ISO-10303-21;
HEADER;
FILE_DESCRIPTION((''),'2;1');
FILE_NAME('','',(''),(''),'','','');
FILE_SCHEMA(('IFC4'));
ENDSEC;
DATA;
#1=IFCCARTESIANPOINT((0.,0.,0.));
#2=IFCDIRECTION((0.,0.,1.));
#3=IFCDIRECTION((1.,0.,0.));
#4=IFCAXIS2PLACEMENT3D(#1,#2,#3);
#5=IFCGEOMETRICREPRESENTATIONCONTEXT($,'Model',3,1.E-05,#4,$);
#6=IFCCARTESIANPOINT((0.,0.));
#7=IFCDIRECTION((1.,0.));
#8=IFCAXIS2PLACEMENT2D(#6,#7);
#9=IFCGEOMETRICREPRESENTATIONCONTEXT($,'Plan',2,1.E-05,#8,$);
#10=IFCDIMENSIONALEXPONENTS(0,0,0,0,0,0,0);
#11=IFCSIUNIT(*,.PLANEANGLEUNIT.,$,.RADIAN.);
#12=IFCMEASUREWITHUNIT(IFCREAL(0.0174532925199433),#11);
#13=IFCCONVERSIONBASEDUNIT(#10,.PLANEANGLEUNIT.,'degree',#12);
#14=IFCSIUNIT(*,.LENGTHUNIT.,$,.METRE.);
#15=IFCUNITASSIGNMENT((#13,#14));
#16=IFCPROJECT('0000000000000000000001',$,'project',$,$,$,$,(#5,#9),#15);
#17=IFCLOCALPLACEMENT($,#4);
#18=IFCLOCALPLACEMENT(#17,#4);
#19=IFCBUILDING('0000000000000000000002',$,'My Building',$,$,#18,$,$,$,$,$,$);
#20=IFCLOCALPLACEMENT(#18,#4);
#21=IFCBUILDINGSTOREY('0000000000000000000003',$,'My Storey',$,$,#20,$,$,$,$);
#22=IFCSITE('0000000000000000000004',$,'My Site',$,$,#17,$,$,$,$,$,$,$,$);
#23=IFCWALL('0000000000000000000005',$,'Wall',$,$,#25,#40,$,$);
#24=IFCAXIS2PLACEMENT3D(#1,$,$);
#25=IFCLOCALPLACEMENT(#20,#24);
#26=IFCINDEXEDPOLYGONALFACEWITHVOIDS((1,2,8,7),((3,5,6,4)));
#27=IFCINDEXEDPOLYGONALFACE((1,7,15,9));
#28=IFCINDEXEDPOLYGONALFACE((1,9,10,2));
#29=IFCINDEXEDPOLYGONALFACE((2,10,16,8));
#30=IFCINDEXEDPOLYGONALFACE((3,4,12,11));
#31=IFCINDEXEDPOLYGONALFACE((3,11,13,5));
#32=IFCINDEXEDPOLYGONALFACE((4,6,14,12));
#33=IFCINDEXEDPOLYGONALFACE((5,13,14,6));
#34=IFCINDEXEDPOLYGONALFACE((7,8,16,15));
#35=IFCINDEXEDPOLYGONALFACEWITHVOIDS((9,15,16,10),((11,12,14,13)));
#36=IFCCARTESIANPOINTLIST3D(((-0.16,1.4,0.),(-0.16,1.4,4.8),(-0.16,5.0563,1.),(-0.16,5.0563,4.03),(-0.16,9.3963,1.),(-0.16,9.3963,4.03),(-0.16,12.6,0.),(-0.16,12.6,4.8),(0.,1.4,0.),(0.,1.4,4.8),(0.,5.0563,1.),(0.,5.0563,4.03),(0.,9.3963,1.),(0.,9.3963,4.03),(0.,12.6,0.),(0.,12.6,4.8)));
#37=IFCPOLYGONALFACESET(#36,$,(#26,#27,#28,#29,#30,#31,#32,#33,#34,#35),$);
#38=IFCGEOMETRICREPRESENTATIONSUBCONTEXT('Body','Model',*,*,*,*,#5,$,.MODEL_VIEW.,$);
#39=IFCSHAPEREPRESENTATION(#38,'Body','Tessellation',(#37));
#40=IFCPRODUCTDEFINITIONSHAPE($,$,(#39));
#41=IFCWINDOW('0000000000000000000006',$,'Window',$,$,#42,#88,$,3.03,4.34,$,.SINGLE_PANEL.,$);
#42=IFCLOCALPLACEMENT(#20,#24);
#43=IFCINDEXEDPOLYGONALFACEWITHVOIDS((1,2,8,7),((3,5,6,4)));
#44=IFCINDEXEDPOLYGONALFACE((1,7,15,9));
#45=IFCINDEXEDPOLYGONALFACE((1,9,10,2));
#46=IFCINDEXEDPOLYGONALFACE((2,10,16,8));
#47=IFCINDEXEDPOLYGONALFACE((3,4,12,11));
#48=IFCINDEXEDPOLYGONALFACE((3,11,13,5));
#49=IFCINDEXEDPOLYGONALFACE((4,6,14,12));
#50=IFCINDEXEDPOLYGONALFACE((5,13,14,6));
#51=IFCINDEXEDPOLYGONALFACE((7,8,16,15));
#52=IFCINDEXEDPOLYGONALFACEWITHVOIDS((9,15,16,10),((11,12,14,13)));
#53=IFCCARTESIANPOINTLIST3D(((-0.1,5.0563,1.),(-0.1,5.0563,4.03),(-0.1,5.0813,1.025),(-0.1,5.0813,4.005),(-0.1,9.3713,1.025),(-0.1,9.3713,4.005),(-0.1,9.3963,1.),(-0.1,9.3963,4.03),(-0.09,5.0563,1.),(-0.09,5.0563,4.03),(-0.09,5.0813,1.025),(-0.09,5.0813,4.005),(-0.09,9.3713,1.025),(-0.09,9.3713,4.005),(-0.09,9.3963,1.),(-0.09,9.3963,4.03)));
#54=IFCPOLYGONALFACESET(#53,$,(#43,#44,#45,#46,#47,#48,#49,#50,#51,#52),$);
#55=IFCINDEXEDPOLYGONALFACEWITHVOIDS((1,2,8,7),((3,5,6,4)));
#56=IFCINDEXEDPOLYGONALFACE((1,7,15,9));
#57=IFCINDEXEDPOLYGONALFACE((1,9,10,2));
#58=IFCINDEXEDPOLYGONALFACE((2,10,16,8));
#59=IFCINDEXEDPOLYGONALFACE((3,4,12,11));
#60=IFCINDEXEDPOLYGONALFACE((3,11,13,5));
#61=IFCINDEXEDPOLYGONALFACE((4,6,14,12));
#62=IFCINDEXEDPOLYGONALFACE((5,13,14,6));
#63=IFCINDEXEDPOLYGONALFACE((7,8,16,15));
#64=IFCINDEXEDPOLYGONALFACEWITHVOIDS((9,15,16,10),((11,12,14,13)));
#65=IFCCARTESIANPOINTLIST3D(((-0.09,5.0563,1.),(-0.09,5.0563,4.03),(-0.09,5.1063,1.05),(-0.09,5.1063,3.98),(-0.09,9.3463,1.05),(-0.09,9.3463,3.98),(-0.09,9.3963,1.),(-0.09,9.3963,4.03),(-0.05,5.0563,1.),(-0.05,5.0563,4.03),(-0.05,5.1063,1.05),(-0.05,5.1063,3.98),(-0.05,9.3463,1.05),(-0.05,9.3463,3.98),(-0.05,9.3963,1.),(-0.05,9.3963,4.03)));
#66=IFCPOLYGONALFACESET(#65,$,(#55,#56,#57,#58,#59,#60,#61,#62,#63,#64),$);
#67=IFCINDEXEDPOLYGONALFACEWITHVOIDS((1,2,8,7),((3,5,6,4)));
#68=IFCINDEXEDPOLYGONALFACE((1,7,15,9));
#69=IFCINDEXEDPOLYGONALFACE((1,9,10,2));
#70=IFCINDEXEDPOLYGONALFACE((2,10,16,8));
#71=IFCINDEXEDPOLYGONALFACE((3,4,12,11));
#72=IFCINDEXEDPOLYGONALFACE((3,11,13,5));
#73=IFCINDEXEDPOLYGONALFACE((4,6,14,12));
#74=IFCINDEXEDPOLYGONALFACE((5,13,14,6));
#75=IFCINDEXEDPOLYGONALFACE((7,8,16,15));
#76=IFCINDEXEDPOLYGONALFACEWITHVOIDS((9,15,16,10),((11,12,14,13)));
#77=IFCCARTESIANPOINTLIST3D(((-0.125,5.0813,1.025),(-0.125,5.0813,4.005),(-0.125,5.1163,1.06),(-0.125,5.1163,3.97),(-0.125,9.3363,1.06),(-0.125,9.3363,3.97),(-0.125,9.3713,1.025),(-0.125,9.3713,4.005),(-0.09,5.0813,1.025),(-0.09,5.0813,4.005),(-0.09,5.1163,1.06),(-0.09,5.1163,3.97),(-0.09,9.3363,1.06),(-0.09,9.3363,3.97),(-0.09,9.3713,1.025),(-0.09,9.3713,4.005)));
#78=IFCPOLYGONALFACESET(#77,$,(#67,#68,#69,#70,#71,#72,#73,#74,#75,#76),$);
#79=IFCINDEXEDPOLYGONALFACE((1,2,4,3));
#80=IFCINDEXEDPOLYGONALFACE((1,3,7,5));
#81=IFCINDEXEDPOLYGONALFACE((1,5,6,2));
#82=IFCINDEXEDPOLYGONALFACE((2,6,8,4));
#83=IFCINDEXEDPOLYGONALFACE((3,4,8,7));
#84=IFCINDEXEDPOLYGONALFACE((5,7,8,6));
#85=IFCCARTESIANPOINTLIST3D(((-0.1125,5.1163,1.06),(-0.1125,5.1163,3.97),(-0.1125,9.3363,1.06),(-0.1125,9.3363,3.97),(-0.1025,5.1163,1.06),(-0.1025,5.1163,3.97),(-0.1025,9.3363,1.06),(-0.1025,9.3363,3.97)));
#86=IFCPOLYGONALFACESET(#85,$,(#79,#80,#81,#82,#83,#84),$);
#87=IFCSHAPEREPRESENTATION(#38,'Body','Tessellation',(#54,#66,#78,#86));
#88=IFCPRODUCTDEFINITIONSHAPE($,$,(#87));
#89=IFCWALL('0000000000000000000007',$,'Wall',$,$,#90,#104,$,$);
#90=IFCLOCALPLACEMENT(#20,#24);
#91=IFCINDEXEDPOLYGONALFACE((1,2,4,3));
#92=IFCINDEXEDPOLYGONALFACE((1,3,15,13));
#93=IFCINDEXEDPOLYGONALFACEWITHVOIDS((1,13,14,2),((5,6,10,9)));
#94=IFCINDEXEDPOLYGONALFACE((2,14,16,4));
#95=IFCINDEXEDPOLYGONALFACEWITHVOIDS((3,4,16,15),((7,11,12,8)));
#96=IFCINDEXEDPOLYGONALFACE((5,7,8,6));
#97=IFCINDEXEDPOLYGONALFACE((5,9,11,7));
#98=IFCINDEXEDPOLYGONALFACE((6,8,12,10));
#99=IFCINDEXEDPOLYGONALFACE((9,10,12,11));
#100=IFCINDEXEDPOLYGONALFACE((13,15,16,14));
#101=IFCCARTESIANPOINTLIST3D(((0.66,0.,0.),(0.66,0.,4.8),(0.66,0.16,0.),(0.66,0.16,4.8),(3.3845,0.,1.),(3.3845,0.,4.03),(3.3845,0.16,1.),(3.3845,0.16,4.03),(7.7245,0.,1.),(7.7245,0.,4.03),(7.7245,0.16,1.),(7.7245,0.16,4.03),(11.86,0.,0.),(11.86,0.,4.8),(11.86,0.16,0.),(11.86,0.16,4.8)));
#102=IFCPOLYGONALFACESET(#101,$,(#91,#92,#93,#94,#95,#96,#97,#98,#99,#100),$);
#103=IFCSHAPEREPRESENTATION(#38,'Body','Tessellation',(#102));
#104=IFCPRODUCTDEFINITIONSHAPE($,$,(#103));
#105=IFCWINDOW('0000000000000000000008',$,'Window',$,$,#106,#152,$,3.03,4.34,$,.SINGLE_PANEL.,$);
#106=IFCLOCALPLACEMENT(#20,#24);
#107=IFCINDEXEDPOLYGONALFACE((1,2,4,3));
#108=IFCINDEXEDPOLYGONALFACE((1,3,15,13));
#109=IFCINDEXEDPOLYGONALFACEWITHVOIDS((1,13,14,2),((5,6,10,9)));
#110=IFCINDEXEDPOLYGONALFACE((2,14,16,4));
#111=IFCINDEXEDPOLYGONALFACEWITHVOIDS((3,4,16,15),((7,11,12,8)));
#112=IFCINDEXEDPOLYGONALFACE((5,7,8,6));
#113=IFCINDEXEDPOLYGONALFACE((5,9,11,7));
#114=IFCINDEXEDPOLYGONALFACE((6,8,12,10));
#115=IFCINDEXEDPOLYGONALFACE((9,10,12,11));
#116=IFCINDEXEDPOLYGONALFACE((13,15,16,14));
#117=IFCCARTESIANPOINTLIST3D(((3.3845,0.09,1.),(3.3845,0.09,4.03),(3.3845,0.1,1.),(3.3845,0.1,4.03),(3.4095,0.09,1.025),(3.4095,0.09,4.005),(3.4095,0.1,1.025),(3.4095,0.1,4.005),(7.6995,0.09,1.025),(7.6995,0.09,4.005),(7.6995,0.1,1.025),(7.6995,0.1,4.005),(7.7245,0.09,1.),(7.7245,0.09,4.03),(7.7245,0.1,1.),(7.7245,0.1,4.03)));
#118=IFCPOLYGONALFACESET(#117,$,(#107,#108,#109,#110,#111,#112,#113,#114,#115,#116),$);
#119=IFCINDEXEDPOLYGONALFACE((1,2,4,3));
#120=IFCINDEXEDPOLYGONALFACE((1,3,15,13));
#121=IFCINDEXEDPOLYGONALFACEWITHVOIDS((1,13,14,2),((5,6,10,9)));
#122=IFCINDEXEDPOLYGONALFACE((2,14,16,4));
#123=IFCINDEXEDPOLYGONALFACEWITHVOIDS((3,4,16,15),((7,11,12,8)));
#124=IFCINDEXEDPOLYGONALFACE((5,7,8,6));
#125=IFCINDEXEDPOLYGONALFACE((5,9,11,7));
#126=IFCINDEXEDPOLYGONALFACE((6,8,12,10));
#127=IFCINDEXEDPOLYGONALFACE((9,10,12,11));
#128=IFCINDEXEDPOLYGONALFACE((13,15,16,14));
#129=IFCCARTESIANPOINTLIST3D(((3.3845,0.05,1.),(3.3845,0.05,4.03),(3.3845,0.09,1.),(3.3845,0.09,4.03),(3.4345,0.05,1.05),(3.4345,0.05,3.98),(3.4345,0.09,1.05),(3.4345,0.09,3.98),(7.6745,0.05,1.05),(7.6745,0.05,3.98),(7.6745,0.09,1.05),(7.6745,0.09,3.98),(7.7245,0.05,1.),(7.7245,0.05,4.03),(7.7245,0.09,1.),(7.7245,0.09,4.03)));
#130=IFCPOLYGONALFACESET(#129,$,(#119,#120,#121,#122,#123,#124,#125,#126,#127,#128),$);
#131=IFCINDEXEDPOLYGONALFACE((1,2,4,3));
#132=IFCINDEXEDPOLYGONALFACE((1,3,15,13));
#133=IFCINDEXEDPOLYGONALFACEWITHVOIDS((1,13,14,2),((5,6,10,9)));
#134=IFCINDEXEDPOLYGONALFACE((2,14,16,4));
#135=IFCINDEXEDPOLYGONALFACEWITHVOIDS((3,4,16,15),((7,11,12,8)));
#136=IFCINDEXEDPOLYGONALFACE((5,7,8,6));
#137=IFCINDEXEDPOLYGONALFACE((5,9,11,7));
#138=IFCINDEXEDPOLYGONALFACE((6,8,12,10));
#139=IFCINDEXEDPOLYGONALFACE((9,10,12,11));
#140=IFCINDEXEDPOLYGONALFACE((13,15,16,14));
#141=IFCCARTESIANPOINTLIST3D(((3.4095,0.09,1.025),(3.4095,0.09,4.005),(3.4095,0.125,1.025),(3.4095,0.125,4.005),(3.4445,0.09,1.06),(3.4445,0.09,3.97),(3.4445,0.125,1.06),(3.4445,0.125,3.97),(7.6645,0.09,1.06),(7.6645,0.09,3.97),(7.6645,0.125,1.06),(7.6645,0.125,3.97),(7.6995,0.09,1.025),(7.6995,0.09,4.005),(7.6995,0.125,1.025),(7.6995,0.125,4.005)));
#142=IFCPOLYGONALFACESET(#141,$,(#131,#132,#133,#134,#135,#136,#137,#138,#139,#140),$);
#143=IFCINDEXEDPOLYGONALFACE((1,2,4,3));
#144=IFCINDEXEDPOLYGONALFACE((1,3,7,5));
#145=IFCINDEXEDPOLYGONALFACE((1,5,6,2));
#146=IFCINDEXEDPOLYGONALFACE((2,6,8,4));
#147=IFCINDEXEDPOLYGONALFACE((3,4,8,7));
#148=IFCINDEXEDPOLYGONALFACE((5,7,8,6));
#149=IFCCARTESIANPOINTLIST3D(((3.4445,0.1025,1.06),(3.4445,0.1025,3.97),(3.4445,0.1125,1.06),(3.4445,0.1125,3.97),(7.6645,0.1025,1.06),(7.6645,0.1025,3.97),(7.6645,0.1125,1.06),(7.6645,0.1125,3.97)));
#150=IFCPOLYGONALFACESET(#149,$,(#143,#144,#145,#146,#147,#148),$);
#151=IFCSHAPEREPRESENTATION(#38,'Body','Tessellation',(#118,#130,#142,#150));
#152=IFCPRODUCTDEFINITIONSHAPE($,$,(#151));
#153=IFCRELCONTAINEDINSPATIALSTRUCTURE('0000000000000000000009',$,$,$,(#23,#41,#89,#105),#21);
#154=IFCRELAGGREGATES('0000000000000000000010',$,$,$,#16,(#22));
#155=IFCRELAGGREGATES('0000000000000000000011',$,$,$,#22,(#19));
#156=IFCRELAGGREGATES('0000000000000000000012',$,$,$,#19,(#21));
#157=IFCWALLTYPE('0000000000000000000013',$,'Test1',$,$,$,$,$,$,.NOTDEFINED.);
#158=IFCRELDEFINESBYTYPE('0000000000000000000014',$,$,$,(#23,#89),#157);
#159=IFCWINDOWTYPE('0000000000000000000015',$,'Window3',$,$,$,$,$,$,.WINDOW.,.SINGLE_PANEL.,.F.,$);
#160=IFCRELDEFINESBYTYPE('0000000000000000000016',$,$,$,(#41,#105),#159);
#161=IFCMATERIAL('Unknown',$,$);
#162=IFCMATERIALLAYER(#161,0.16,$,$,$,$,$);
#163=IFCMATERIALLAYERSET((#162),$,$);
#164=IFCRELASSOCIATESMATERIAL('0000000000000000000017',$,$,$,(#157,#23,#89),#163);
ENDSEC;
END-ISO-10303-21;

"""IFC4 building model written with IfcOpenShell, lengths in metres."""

from ifc_helpers import new_model, entity, si_unit, converted_unit, frame, origin_with_axes, origin_2d_with_axis, place, context, subcontext, project, spatial, line, indexed_curve, outline, extrude, shape, source, transform, mapped, material, layer, layer_set, layer_usage, type_object, type_shapes, element, fill, save


model = new_model("IFC4")

# Units and contexts
model_context = context("Model", 3, precision=1e-05, world=origin_with_axes())
plan_context = context("Plan", 2, precision=1e-05, world=origin_2d_with_axis())
body_context_1 = subcontext(model_context, "Body", "Model", "MODEL_VIEW")
body_context_2 = subcontext(plan_context, "Body", "Plan", "PLAN_VIEW")
ifc_project = project(units=[converted_unit("PLANEANGLEUNIT", "degree", entity("IfcReal", 0.0174532925199433), si_unit("PLANEANGLEUNIT", "RADIAN"), dimensions=[0, 0, 0, 0, 0, 0, 0]), si_unit("LENGTHUNIT", "METRE")], contexts=[model_context, plan_context])

# Site, building, storey
site_placement = place(None, origin_with_axes())
site = spatial("IfcSite", under=ifc_project, at=site_placement, Name="My Site")
building_placement = place(site_placement, origin_with_axes())
building = spatial("IfcBuilding", under=site, at=building_placement, Name="My Building")
storey_placement = place(building_placement, origin_with_axes())
storey = spatial("IfcBuildingStorey", under=building, at=storey_placement, Name="My Storey")

# Shared definitions
ifc_material = material(Name="Unknown")
ifc_layer = layer(ifc_material, 0.16)
ifc_layer_set = layer_set([ifc_layer])
wall_type = type_object("IfcWallType", Name="Test1", PredefinedType="NOTDEFINED", material=ifc_layer_set)
shared_shape_1 = source(origin_with_axes(), body_context_1, "Body", "SweptSolid", [
    extrude(outline(indexed_curve([(0.0, 0.0), (4.34, 0.0), (4.34, 3.03), (0.0, 3.03)], segments=[line(1, 2, 3, 4, 1)])), frame((0.0, -0.1, 0.0), z_axis=(0.0, -1.0, 0.0), x_axis=(1.0, 0.0, 0.0)), (0.0, 0.0, -1.0), 0.36),
])
window_type = type_object("IfcWindowType", Name="Window3", ParameterTakesPrecedence=False, PartitioningType="SINGLE_PANEL", PredefinedType="WINDOW")
shared_shape_2 = source(origin_with_axes(), body_context_1, "Body", "SweptSolid", [
    extrude(outline(indexed_curve([(0.0, 0.0), (4.34, 0.0), (4.34, 3.03), (0.0, 3.03)], segments=[line(1, 2, 3, 4, 1)]), holes=[indexed_curve([(0.025, 0.025), (4.315, 0.025), (4.315, 3.005), (0.025, 3.005)], segments=[line(1, 2, 3, 4, 1)])]), frame((0.0, 0.09, 0.0), z_axis=(0.0, -1.0, 0.0), x_axis=(1.0, 0.0, 0.0)), (0.0, 0.0, -1.0), 0.01),
    extrude(outline(indexed_curve([(0.0, 0.0), (4.34, 0.0), (4.34, 3.03), (0.0, 3.03)], segments=[line(1, 2, 3, 4, 1)]), holes=[indexed_curve([(0.05, 0.05), (4.29, 0.05), (4.29, 2.98), (0.05, 2.98)], segments=[line(1, 2, 3, 4, 1)])]), frame((0.0, 0.05, 0.0), z_axis=(0.0, -1.0, 0.0), x_axis=(1.0, 0.0, 0.0)), (0.0, 0.0, -1.0), 0.04),
    extrude(outline(indexed_curve([(0.0, 0.0), (4.29, 0.0), (4.29, 2.98), (0.0, 2.98)], segments=[line(1, 2, 3, 4, 1)]), holes=[indexed_curve([(0.035, 0.035), (4.255, 0.035), (4.255, 2.945), (0.035, 2.945)], segments=[line(1, 2, 3, 4, 1)])]), frame((0.025, 0.09, 0.025), z_axis=(0.0, -1.0, 0.0), x_axis=(1.0, 0.0, 0.0)), (0.0, 0.0, -1.0), 0.035),
    extrude(outline(indexed_curve([(0.035, 0.035), (4.255, 0.035), (4.255, 2.945), (0.035, 2.945)], segments=[line(1, 2, 3, 4, 1)])), frame((0.025, 0.1025, 0.025), z_axis=(0.0, -1.0, 0.0), x_axis=(1.0, 0.0, 0.0)), (0.0, 0.0, -1.0), 0.01),
])
shared_shape_3 = source(origin_with_axes(), body_context_2, "Body", "Curve2D", [
    entity("IfcIndexedPolyCurve", entity("IfcCartesianPointList2D", [[0.05, 0.05], [4.29, 0.05]])),
    entity("IfcIndexedPolyCurve", entity("IfcCartesianPointList2D", [[0.0, 0.1], [0.025, 0.1], [0.025, 0.09], [0.05, 0.09], [0.05, 0.05], [0.0, 0.05]]), [entity("IfcLineIndex", [1, 2, 3, 4, 5, 6, 1])]),
    entity("IfcIndexedPolyCurve", entity("IfcCartesianPointList2D", [[4.34, 0.1], [4.315, 0.1], [4.315, 0.09], [4.29, 0.09], [4.29, 0.05], [4.34, 0.05]]), [entity("IfcLineIndex", [1, 2, 3, 4, 5, 6, 1])]),
    entity("IfcIndexedPolyCurve", entity("IfcCartesianPointList2D", [[0.025, 0.09], [0.06, 0.09], [0.06, 0.125], [0.025, 0.125]]), [entity("IfcLineIndex", [1, 2, 3, 4, 1])]),
    entity("IfcIndexedPolyCurve", entity("IfcCartesianPointList2D", [[4.315, 0.09], [4.28, 0.09], [4.28, 0.125], [4.315, 0.125]]), [entity("IfcLineIndex", [1, 2, 3, 4, 1])]),
    entity("IfcIndexedPolyCurve", entity("IfcCartesianPointList2D", [[0.06, 0.09], [4.28, 0.09]])),
    entity("IfcIndexedPolyCurve", entity("IfcCartesianPointList2D", [[0.06, 0.125], [4.28, 0.125]])),
    entity("IfcIndexedPolyCurve", entity("IfcCartesianPointList2D", [[0.06, 0.1075], [4.28, 0.1075]])),
])
type_shapes(window_type, [shared_shape_2, shared_shape_3])

# Walls, openings, windows
ifc_layer_usage_1 = layer_usage(ifc_layer_set, "AXIS2", "POSITIVE", 0.0)
wall_1_placement = place(storey_placement, frame((0.0, 1.4, 0.0), z_axis=(0.0, 0.0, 1.0), x_axis=(0.0, 1.0, 0.0)))
wall_1 = element("IfcWall", 1, at=wall_1_placement, inside=storey, type_object=wall_type, material=ifc_layer_usage_1, Name="Wall", context=body_context_1, shape_type="SweptSolid", body=[
    extrude(outline(indexed_curve([(0.0, 0.0), (0.0, 0.16), (11.2, 0.16), (11.2, 0.0), (0.0, 0.0)], self_intersect=False)), origin_with_axes(), (0.0, 0.0, 1.0), 4.8),
])
opening_1_placement = place(wall_1_placement, frame((3.6563, 0.0, 1.0), z_axis=(0.0, 0.0, 1.0), x_axis=(1.0, 0.0, 0.0)))
opening_1 = element("IfcOpeningElement", 2, at=opening_1_placement, cuts=wall_1, PredefinedType="OPENING", context=body_context_1, shape_type="MappedRepresentation", body=[
    mapped(shared_shape_1, transform((0.0, 0.0, 0.0), x_axis=(1.0, 0.0, 0.0), y_axis=(0.0, 1.0, 0.0), z_axis=(0.0, 0.0, 1.0), scale=1.0)),
])
window_1_placement = place(opening_1_placement, frame((0.0, 0.0, 0.0), z_axis=(0.0, 0.0, 1.0), x_axis=(1.0, 0.0, 0.0)))
window_1 = element("IfcWindow", 3, at=window_1_placement, inside=storey, type_object=window_type, Name="Window", OverallHeight=3.03, OverallWidth=4.34, PartitioningType="SINGLE_PANEL", shapes=[
    shape(body_context_1, "Body", "MappedRepresentation", [mapped(shared_shape_2, transform((0.0, 0.0, 0.0), x_axis=(1.0, 0.0, 0.0), y_axis=(0.0, 1.0, 0.0), z_axis=(0.0, 0.0, 1.0), scale=1.0))]),
    shape(body_context_2, "Body", "MappedRepresentation", [mapped(shared_shape_3, transform((0.0, 0.0, 0.0), x_axis=(1.0, 0.0, 0.0), y_axis=(0.0, 1.0, 0.0), z_axis=(0.0, 0.0, 1.0), scale=1.0))]),
])
fill(opening_1, window_1)
ifc_layer_usage_2 = layer_usage(ifc_layer_set, "AXIS2", "POSITIVE", 0.0)
wall_2_placement = place(storey_placement, frame((0.66, 0.0, 0.0), z_axis=(0.0, 0.0, 1.0), x_axis=(1.0, 0.0, 0.0)))
wall_2 = element("IfcWall", 4, at=wall_2_placement, inside=storey, type_object=wall_type, material=ifc_layer_usage_2, Name="Wall", context=body_context_1, shape_type="SweptSolid", body=[
    extrude(outline(indexed_curve([(0.0, 0.0), (0.0, 0.16), (11.2, 0.16), (11.2, 0.0), (0.0, 0.0)], self_intersect=False)), origin_with_axes(), (0.0, 0.0, 1.0), 4.8),
])
opening_2_placement = place(wall_2_placement, frame((2.7245, 0.0, 1.0), z_axis=(0.0, 0.0, 1.0), x_axis=(1.0, 0.0, 0.0)))
opening_2 = element("IfcOpeningElement", 5, at=opening_2_placement, cuts=wall_2, PredefinedType="OPENING", context=body_context_1, shape_type="MappedRepresentation", body=[
    mapped(shared_shape_1, transform((0.0, 0.0, 0.0), x_axis=(1.0, 0.0, 0.0), y_axis=(0.0, 1.0, 0.0), z_axis=(0.0, 0.0, 1.0), scale=1.0)),
])
window_2_placement = place(opening_2_placement, origin_with_axes())
window_2 = element("IfcWindow", 6, at=window_2_placement, inside=storey, type_object=window_type, Name="Window", OverallHeight=3.03, OverallWidth=4.34, PartitioningType="SINGLE_PANEL", shapes=[
    shape(body_context_1, "Body", "MappedRepresentation", [mapped(shared_shape_2, transform((0.0, 0.0, 0.0), x_axis=(1.0, 0.0, 0.0), y_axis=(0.0, 1.0, 0.0), z_axis=(0.0, 0.0, 1.0), scale=1.0))]),
    shape(body_context_2, "Body", "MappedRepresentation", [mapped(shared_shape_3, transform((0.0, 0.0, 0.0), x_axis=(1.0, 0.0, 0.0), y_axis=(0.0, 1.0, 0.0), z_axis=(0.0, 0.0, 1.0), scale=1.0))]),
])
fill(opening_2, window_2)

save(model, "model.ifc")
